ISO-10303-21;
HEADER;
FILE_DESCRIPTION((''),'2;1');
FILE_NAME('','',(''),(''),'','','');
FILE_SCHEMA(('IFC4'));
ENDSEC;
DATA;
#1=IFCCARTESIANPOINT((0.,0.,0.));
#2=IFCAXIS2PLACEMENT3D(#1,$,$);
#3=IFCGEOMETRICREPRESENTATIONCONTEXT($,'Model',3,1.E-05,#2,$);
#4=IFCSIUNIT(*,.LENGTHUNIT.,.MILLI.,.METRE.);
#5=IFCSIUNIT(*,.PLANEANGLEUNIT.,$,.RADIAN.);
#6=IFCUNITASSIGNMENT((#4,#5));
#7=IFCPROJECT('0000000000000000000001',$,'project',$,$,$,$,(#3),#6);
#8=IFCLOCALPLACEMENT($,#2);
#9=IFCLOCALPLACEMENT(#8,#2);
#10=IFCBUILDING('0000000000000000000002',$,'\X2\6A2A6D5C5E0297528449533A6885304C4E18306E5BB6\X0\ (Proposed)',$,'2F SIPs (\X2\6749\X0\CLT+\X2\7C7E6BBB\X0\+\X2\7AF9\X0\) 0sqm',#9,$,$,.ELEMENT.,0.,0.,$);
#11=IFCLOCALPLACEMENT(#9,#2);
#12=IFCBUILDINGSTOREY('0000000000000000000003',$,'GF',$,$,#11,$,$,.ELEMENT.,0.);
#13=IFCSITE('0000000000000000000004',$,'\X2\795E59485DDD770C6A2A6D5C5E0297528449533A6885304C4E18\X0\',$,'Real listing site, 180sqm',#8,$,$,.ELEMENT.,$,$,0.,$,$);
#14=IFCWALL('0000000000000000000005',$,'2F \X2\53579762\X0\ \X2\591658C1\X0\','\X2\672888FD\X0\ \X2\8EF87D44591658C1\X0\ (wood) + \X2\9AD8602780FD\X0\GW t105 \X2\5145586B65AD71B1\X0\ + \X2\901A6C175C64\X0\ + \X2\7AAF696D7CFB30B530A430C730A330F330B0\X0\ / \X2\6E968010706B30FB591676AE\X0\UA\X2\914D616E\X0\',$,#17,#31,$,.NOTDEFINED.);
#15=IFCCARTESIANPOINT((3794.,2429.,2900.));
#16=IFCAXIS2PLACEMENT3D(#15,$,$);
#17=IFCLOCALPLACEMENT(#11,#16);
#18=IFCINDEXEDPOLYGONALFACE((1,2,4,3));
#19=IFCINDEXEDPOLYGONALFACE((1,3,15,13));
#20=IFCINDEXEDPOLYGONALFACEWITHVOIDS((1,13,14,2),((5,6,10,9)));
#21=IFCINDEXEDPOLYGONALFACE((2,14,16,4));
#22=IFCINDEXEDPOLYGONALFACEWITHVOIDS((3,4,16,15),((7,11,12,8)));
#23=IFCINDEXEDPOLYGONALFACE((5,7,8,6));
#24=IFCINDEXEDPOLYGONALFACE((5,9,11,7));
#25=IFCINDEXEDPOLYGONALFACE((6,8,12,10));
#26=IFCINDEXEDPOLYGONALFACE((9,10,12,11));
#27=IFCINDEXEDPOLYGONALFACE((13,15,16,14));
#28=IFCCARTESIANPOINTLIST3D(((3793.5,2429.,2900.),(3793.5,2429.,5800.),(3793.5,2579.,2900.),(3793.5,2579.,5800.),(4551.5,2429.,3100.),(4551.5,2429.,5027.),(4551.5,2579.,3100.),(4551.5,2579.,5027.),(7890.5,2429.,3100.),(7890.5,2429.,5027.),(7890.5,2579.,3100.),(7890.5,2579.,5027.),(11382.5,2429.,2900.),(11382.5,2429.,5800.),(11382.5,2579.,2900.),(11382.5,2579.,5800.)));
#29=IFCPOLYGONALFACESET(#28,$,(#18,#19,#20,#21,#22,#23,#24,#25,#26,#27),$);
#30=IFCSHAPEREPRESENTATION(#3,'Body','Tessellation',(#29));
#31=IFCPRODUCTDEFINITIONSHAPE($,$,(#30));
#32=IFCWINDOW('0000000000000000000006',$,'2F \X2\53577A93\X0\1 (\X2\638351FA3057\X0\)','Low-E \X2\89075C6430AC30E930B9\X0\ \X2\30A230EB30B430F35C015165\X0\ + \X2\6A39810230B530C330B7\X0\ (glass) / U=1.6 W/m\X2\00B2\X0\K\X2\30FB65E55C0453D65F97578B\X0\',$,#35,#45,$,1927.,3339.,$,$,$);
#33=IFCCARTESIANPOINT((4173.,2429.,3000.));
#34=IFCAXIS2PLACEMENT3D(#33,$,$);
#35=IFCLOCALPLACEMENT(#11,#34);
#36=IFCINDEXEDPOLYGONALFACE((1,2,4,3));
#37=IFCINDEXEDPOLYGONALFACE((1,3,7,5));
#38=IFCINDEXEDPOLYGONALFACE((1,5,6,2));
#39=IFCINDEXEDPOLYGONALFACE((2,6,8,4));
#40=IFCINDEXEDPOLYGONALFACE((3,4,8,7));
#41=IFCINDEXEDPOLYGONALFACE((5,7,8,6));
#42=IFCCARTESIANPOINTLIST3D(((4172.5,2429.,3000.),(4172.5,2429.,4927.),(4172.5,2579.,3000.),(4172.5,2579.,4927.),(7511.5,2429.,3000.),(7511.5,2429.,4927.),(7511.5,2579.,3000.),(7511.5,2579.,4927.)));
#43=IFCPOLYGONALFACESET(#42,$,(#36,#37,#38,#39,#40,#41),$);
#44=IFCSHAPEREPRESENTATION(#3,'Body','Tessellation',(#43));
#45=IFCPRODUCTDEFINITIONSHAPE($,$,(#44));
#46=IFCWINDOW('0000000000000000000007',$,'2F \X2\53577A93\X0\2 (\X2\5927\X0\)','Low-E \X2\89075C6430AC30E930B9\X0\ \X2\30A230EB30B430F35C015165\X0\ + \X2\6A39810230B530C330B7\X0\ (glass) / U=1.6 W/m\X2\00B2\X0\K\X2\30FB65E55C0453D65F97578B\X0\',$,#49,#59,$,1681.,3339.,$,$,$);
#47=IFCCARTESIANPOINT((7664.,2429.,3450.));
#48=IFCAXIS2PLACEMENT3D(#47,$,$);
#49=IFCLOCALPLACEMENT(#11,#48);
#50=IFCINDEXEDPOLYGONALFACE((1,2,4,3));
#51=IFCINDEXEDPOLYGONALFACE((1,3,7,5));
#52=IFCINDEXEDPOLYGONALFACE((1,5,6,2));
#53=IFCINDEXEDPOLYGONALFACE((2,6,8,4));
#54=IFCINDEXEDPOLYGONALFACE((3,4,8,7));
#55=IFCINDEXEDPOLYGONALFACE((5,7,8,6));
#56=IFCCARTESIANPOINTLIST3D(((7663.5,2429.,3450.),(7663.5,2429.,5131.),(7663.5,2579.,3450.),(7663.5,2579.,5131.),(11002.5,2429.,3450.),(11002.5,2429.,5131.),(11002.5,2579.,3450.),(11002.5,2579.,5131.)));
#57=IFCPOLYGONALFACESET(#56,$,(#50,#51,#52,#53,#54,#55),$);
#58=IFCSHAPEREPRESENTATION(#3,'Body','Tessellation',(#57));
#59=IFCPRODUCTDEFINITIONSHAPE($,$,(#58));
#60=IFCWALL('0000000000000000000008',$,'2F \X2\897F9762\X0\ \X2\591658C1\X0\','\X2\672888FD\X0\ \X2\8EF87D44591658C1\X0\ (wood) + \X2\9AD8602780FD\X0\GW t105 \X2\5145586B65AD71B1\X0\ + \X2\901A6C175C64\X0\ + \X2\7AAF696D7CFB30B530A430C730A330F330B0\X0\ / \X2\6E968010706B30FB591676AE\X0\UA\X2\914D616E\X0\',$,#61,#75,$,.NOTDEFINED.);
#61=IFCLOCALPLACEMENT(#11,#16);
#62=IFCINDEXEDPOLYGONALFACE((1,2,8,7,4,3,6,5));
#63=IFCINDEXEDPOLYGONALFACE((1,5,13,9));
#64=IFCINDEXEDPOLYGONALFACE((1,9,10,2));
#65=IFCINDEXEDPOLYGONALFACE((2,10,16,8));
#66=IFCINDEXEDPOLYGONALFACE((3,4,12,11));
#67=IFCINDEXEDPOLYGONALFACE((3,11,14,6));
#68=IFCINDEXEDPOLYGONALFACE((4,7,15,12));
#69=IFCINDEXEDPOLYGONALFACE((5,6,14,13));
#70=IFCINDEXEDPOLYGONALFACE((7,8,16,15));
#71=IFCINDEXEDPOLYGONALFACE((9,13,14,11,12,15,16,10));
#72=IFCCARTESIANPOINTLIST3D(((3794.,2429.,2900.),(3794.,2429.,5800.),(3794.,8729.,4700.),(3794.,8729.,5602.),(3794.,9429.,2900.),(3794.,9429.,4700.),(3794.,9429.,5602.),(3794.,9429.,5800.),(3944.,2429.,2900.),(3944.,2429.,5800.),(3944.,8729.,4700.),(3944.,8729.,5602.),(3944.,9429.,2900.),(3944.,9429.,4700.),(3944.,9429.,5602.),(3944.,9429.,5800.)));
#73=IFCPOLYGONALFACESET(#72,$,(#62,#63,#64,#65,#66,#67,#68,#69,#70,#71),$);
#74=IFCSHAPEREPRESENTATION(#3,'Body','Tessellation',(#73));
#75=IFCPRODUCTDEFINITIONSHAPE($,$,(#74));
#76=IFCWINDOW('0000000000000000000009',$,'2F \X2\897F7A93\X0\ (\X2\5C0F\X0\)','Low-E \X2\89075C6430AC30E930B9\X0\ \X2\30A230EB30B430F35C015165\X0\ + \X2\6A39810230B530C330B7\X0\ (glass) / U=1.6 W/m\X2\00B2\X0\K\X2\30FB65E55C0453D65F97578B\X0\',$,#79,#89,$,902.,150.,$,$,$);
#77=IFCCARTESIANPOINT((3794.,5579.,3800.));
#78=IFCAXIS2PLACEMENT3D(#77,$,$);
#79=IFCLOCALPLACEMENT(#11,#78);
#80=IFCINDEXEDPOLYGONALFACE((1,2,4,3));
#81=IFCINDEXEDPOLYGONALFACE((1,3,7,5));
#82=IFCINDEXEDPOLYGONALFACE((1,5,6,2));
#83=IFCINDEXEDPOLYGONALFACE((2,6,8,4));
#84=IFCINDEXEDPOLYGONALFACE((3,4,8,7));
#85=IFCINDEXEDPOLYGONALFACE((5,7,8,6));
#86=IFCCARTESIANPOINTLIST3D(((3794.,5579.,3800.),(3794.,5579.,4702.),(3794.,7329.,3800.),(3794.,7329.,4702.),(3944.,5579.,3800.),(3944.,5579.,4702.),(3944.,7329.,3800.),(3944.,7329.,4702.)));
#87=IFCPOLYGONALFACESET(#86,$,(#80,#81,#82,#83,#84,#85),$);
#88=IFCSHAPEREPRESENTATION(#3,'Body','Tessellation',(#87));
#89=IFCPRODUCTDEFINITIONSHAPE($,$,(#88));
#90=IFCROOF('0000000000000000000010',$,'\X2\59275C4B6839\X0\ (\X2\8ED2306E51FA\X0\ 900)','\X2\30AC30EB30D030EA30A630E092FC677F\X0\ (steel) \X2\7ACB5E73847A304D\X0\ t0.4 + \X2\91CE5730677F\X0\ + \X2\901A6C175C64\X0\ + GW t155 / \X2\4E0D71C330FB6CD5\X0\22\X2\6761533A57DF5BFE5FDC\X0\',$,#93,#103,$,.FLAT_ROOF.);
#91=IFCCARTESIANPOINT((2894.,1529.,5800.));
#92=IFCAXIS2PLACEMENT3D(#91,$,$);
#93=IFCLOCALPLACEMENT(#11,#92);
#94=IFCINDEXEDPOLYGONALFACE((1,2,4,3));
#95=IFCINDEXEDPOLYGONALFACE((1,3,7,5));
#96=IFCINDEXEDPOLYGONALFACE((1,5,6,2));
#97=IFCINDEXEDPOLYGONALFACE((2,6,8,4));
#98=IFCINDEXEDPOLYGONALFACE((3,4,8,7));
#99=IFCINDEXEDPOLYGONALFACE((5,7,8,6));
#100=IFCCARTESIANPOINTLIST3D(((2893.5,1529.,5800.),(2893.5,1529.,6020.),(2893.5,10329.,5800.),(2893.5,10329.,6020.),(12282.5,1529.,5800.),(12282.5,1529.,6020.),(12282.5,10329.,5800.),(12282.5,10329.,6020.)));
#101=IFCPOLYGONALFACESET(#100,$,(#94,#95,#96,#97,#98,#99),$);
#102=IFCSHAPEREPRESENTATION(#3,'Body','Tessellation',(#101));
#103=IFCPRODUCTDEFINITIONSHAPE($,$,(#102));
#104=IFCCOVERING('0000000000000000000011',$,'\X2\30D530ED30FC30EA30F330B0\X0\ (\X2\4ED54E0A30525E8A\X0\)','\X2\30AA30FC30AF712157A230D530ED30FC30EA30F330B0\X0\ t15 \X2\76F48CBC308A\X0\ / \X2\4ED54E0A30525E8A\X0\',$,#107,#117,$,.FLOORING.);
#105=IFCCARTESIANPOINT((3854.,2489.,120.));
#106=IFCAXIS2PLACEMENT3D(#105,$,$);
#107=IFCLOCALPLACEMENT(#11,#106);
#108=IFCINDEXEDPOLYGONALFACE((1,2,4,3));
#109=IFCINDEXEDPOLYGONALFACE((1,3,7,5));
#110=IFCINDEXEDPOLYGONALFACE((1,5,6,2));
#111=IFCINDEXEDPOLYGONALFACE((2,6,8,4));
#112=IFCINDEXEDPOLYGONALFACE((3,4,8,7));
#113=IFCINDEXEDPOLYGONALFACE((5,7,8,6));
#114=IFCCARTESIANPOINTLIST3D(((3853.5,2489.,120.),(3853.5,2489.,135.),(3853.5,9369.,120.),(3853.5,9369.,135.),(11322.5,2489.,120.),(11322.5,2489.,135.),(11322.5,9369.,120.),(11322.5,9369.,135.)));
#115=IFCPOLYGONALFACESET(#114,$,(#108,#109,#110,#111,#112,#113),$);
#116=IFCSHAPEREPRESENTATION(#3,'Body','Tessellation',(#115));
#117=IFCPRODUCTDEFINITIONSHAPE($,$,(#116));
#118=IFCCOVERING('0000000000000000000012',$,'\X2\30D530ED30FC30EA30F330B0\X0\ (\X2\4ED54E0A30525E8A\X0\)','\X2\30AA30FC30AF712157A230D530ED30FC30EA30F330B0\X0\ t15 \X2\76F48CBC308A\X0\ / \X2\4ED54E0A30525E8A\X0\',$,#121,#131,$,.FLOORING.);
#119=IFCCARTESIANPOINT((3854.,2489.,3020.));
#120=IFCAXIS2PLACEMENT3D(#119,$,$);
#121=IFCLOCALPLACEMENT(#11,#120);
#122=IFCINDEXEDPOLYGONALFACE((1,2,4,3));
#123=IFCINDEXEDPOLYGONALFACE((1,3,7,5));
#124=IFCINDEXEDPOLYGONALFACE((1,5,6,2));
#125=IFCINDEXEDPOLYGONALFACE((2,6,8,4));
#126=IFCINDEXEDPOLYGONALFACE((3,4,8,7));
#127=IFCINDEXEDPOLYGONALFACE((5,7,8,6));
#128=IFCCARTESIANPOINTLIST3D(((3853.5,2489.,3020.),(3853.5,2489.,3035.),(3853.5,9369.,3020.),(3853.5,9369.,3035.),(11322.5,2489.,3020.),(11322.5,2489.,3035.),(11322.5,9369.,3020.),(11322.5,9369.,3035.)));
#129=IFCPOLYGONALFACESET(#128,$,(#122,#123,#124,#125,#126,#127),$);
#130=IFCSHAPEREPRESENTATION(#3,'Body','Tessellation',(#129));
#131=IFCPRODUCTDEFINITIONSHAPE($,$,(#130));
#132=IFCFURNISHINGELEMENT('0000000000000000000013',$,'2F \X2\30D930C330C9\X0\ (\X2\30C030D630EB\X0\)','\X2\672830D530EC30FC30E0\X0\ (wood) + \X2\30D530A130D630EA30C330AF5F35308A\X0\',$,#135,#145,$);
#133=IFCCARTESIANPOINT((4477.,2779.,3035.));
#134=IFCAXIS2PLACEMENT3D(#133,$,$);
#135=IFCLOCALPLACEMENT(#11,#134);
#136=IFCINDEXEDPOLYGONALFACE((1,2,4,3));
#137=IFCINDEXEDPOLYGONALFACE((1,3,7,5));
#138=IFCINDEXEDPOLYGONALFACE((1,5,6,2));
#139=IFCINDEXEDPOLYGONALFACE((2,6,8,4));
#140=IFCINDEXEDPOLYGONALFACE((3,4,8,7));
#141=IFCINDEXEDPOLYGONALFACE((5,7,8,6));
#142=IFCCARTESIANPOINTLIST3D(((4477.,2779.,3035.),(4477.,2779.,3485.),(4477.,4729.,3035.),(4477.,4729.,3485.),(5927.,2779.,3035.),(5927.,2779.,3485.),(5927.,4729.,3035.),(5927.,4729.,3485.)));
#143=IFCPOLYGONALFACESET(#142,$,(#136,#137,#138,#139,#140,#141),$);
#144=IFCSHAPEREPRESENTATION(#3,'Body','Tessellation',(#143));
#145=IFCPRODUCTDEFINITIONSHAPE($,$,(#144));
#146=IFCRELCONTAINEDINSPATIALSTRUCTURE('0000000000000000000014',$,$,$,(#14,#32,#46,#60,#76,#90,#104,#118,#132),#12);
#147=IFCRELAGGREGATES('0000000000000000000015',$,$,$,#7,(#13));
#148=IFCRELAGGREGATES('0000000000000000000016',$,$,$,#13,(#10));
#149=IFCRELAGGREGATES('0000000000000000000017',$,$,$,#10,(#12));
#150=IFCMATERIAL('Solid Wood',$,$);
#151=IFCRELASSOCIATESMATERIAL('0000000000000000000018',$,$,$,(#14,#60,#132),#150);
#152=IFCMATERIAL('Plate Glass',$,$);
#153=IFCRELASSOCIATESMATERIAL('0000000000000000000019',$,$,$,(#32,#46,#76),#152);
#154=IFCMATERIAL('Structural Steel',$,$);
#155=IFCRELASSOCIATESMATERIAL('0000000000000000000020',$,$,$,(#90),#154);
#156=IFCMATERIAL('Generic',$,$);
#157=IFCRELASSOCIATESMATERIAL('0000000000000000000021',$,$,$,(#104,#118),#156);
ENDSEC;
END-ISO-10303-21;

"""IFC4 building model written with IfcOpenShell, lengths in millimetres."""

from ifc_helpers import new_model, si_unit, frame, frame_2d, origin, place, context, project, spatial, rectangle, extrude, material, element, fill, save


model = new_model("IFC4")

# Units and contexts
model_context = context("Model", 3, precision=1e-05, world=origin())
ifc_project = project(units=[si_unit("LENGTHUNIT", "METRE", prefix="MILLI"), si_unit("PLANEANGLEUNIT", "RADIAN")], contexts=[model_context])

# Site, building, storey
site_placement = place(None, origin())
site = spatial("IfcSite", under=ifc_project, at=site_placement, Name="神奈川県横浜市青葉区梅が丘", ObjectType="Real listing site, 180sqm", CompositionType="ELEMENT", RefElevation=0.0)
building_placement = place(site_placement, origin())
building = spatial("IfcBuilding", under=site, at=building_placement, Name="横浜市青葉区梅が丘の家 (Proposed)", ObjectType="2F SIPs (杉CLT+籾殻+竹) 0sqm", CompositionType="ELEMENT", ElevationOfRefHeight=0.0, ElevationOfTerrain=0.0)
storey_placement = place(building_placement, origin())
storey = spatial("IfcBuildingStorey", under=building, at=storey_placement, Name="GF", CompositionType="ELEMENT", Elevation=0.0)

# Shared definitions
ifc_material_1 = material(Name="Solid Wood")

# Shared definitions
ifc_material_2 = material(Name="Plate Glass")

# Wall, openings, windows
wall_1_placement = place(storey_placement, frame((3794.0, 2429.0, 2900.0)))
wall_1 = element("IfcWall", 1, at=wall_1_placement, inside=storey, material=ifc_material_1, Name="2F 南面 外壁", Description="木製 軸組外壁 (wood) + 高性能GW t105 充填断熱 + 通気層 + 窯業系サイディング / 準耐火・外皮UA配慮", PredefinedType="NOTDEFINED", context=model_context, shape_type="SweptSolid", body=[
    extrude(rectangle(XDim=7589.0, YDim=150.0, at=frame_2d((3794.0, 75.0))), frame((3794.0, 2429.0, 2900.0)), (0.0, 0.0, 1.0), 2900.0),
])
opening_1_placement = place(storey_placement, frame((4173.0, 2429.0, 3000.0)))
opening_1 = element("IfcOpeningElement", 2, at=opening_1_placement, cuts=wall_1, PredefinedType="NOTDEFINED", context=model_context, shape_type="SweptSolid", body=[
    extrude(rectangle(XDim=3339.0, YDim=150.0, at=frame_2d((1669.0, 75.0))), frame((4173.0, 2429.0, 3000.0)), (0.0, 0.0, 1.0), 1927.0),
])
opening_2_placement = place(storey_placement, frame((7664.0, 2429.0, 3450.0)))
opening_2 = element("IfcOpeningElement", 3, at=opening_2_placement, cuts=wall_1, PredefinedType="NOTDEFINED", context=model_context, shape_type="SweptSolid", body=[
    extrude(rectangle(XDim=3339.0, YDim=150.0, at=frame_2d((1669.0, 75.0))), frame((7664.0, 2429.0, 3450.0)), (0.0, 0.0, 1.0), 1681.0),
])
window_1_placement = place(storey_placement, frame((4173.0, 2429.0, 3000.0)))
window_1 = element("IfcWindow", 4, at=window_1_placement, inside=storey, material=ifc_material_2, Name="2F 南窓1 (掃出し)", Description="Low-E 複層ガラス アルゴン封入 + 樹脂サッシ (glass) / U=1.6 W/m²K・日射取得型", OverallHeight=1927.0, OverallWidth=3339.0, context=model_context, shape_type="SweptSolid", body=[
    extrude(rectangle(XDim=3339.0, YDim=150.0, at=frame_2d((1669.0, 75.0))), frame((4173.0, 2429.0, 3000.0)), (0.0, 0.0, 1.0), 1927.0),
])
fill(opening_1, window_1)
window_2_placement = place(storey_placement, frame((7664.0, 2429.0, 3450.0)))
window_2 = element("IfcWindow", 5, at=window_2_placement, inside=storey, material=ifc_material_2, Name="2F 南窓2 (大)", Description="Low-E 複層ガラス アルゴン封入 + 樹脂サッシ (glass) / U=1.6 W/m²K・日射取得型", OverallHeight=1681.0, OverallWidth=3339.0, context=model_context, shape_type="SweptSolid", body=[
    extrude(rectangle(XDim=3339.0, YDim=150.0, at=frame_2d((1669.0, 75.0))), frame((7664.0, 2429.0, 3450.0)), (0.0, 0.0, 1.0), 1681.0),
])
fill(opening_2, window_2)

# Wall, opening, window
wall_2_placement = place(storey_placement, frame((3794.0, 2429.0, 2900.0)))
wall_2 = element("IfcWall", 6, at=wall_2_placement, inside=storey, material=ifc_material_1, Name="2F 西面 外壁", Description="木製 軸組外壁 (wood) + 高性能GW t105 充填断熱 + 通気層 + 窯業系サイディング / 準耐火・外皮UA配慮", PredefinedType="NOTDEFINED", context=model_context, shape_type="SweptSolid", body=[
    extrude(rectangle(XDim=150.0, YDim=7000.0, at=frame_2d((75.0, 3500.0))), frame((3794.0, 2429.0, 2900.0)), (0.0, 0.0, 1.0), 2900.0),
])
opening_3_placement = place(storey_placement, frame((3794.0, 5579.0, 3800.0)))
opening_3 = element("IfcOpeningElement", 7, at=opening_3_placement, cuts=wall_2, PredefinedType="NOTDEFINED", context=model_context, shape_type="SweptSolid", body=[
    extrude(rectangle(XDim=150.0, YDim=1750.0, at=frame_2d((75.0, 875.0))), frame((3794.0, 5579.0, 3800.0)), (0.0, 0.0, 1.0), 902.0),
])
window_3_placement = place(storey_placement, frame((3794.0, 5579.0, 3800.0)))
window_3 = element("IfcWindow", 8, at=window_3_placement, inside=storey, material=ifc_material_2, Name="2F 西窓 (小)", Description="Low-E 複層ガラス アルゴン封入 + 樹脂サッシ (glass) / U=1.6 W/m²K・日射取得型", OverallHeight=902.0, OverallWidth=150.0, context=model_context, shape_type="SweptSolid", body=[
    extrude(rectangle(XDim=150.0, YDim=1750.0, at=frame_2d((75.0, 875.0))), frame((3794.0, 5579.0, 3800.0)), (0.0, 0.0, 1.0), 902.0),
])
fill(opening_3, window_3)

# Roof
ifc_material_3 = material(Name="Structural Steel")
roof_placement = place(storey_placement, frame((2894.0, 1529.0, 5800.0)))
element("IfcRoof", 9, at=roof_placement, inside=storey, material=ifc_material_3, Name="大屋根 (軒の出 900)", Description="ガルバリウム鋼板 (steel) 立平葺き t0.4 + 野地板 + 通気層 + GW t155 / 不燃・法22条区域対応", PredefinedType="FLAT_ROOF", context=model_context, shape_type="SweptSolid", body=[
    extrude(rectangle(XDim=9389.0, YDim=8800.0, at=frame_2d((4694.0, 4400.0))), frame((2894.0, 1529.0, 5800.0)), (0.0, 0.0, 1.0), 220.0),
])

# Coverings
ifc_material_4 = material(Name="Generic")
covering_1_placement = place(storey_placement, frame((3854.0, 2489.0, 120.0)))
element("IfcCovering", 10, at=covering_1_placement, inside=storey, material=ifc_material_4, Name="フローリング (仕上げ床)", Description="オーク無垢フローリング t15 直貼り / 仕上げ床", PredefinedType="FLOORING", context=model_context, shape_type="SweptSolid", body=[
    extrude(rectangle(XDim=7469.0, YDim=6880.0, at=frame_2d((3734.0, 3440.0))), frame((3854.0, 2489.0, 120.0)), (0.0, 0.0, 1.0), 15.0),
])
covering_2_placement = place(storey_placement, frame((3854.0, 2489.0, 3020.0)))
element("IfcCovering", 11, at=covering_2_placement, inside=storey, material=ifc_material_4, Name="フローリング (仕上げ床)", Description="オーク無垢フローリング t15 直貼り / 仕上げ床", PredefinedType="FLOORING", context=model_context, shape_type="SweptSolid", body=[
    extrude(rectangle(XDim=7469.0, YDim=6880.0, at=frame_2d((3734.0, 3440.0))), frame((3854.0, 2489.0, 3020.0)), (0.0, 0.0, 1.0), 15.0),
])

# Furnishing element
furnishing_placement = place(storey_placement, frame((4477.0, 2779.0, 3035.0)))
element("IfcFurnishingElement", 12, at=furnishing_placement, inside=storey, material=ifc_material_1, Name="2F ベッド (ダブル)", Description="木フレーム (wood) + ファブリック張り", context=model_context, shape_type="SweptSolid", body=[
    extrude(rectangle(XDim=1450.0, YDim=1950.0, at=frame_2d((725.0, 975.0))), frame((4477.0, 2779.0, 3035.0)), (0.0, 0.0, 1.0), 450.0),
])

save(model, "model.ifc")
